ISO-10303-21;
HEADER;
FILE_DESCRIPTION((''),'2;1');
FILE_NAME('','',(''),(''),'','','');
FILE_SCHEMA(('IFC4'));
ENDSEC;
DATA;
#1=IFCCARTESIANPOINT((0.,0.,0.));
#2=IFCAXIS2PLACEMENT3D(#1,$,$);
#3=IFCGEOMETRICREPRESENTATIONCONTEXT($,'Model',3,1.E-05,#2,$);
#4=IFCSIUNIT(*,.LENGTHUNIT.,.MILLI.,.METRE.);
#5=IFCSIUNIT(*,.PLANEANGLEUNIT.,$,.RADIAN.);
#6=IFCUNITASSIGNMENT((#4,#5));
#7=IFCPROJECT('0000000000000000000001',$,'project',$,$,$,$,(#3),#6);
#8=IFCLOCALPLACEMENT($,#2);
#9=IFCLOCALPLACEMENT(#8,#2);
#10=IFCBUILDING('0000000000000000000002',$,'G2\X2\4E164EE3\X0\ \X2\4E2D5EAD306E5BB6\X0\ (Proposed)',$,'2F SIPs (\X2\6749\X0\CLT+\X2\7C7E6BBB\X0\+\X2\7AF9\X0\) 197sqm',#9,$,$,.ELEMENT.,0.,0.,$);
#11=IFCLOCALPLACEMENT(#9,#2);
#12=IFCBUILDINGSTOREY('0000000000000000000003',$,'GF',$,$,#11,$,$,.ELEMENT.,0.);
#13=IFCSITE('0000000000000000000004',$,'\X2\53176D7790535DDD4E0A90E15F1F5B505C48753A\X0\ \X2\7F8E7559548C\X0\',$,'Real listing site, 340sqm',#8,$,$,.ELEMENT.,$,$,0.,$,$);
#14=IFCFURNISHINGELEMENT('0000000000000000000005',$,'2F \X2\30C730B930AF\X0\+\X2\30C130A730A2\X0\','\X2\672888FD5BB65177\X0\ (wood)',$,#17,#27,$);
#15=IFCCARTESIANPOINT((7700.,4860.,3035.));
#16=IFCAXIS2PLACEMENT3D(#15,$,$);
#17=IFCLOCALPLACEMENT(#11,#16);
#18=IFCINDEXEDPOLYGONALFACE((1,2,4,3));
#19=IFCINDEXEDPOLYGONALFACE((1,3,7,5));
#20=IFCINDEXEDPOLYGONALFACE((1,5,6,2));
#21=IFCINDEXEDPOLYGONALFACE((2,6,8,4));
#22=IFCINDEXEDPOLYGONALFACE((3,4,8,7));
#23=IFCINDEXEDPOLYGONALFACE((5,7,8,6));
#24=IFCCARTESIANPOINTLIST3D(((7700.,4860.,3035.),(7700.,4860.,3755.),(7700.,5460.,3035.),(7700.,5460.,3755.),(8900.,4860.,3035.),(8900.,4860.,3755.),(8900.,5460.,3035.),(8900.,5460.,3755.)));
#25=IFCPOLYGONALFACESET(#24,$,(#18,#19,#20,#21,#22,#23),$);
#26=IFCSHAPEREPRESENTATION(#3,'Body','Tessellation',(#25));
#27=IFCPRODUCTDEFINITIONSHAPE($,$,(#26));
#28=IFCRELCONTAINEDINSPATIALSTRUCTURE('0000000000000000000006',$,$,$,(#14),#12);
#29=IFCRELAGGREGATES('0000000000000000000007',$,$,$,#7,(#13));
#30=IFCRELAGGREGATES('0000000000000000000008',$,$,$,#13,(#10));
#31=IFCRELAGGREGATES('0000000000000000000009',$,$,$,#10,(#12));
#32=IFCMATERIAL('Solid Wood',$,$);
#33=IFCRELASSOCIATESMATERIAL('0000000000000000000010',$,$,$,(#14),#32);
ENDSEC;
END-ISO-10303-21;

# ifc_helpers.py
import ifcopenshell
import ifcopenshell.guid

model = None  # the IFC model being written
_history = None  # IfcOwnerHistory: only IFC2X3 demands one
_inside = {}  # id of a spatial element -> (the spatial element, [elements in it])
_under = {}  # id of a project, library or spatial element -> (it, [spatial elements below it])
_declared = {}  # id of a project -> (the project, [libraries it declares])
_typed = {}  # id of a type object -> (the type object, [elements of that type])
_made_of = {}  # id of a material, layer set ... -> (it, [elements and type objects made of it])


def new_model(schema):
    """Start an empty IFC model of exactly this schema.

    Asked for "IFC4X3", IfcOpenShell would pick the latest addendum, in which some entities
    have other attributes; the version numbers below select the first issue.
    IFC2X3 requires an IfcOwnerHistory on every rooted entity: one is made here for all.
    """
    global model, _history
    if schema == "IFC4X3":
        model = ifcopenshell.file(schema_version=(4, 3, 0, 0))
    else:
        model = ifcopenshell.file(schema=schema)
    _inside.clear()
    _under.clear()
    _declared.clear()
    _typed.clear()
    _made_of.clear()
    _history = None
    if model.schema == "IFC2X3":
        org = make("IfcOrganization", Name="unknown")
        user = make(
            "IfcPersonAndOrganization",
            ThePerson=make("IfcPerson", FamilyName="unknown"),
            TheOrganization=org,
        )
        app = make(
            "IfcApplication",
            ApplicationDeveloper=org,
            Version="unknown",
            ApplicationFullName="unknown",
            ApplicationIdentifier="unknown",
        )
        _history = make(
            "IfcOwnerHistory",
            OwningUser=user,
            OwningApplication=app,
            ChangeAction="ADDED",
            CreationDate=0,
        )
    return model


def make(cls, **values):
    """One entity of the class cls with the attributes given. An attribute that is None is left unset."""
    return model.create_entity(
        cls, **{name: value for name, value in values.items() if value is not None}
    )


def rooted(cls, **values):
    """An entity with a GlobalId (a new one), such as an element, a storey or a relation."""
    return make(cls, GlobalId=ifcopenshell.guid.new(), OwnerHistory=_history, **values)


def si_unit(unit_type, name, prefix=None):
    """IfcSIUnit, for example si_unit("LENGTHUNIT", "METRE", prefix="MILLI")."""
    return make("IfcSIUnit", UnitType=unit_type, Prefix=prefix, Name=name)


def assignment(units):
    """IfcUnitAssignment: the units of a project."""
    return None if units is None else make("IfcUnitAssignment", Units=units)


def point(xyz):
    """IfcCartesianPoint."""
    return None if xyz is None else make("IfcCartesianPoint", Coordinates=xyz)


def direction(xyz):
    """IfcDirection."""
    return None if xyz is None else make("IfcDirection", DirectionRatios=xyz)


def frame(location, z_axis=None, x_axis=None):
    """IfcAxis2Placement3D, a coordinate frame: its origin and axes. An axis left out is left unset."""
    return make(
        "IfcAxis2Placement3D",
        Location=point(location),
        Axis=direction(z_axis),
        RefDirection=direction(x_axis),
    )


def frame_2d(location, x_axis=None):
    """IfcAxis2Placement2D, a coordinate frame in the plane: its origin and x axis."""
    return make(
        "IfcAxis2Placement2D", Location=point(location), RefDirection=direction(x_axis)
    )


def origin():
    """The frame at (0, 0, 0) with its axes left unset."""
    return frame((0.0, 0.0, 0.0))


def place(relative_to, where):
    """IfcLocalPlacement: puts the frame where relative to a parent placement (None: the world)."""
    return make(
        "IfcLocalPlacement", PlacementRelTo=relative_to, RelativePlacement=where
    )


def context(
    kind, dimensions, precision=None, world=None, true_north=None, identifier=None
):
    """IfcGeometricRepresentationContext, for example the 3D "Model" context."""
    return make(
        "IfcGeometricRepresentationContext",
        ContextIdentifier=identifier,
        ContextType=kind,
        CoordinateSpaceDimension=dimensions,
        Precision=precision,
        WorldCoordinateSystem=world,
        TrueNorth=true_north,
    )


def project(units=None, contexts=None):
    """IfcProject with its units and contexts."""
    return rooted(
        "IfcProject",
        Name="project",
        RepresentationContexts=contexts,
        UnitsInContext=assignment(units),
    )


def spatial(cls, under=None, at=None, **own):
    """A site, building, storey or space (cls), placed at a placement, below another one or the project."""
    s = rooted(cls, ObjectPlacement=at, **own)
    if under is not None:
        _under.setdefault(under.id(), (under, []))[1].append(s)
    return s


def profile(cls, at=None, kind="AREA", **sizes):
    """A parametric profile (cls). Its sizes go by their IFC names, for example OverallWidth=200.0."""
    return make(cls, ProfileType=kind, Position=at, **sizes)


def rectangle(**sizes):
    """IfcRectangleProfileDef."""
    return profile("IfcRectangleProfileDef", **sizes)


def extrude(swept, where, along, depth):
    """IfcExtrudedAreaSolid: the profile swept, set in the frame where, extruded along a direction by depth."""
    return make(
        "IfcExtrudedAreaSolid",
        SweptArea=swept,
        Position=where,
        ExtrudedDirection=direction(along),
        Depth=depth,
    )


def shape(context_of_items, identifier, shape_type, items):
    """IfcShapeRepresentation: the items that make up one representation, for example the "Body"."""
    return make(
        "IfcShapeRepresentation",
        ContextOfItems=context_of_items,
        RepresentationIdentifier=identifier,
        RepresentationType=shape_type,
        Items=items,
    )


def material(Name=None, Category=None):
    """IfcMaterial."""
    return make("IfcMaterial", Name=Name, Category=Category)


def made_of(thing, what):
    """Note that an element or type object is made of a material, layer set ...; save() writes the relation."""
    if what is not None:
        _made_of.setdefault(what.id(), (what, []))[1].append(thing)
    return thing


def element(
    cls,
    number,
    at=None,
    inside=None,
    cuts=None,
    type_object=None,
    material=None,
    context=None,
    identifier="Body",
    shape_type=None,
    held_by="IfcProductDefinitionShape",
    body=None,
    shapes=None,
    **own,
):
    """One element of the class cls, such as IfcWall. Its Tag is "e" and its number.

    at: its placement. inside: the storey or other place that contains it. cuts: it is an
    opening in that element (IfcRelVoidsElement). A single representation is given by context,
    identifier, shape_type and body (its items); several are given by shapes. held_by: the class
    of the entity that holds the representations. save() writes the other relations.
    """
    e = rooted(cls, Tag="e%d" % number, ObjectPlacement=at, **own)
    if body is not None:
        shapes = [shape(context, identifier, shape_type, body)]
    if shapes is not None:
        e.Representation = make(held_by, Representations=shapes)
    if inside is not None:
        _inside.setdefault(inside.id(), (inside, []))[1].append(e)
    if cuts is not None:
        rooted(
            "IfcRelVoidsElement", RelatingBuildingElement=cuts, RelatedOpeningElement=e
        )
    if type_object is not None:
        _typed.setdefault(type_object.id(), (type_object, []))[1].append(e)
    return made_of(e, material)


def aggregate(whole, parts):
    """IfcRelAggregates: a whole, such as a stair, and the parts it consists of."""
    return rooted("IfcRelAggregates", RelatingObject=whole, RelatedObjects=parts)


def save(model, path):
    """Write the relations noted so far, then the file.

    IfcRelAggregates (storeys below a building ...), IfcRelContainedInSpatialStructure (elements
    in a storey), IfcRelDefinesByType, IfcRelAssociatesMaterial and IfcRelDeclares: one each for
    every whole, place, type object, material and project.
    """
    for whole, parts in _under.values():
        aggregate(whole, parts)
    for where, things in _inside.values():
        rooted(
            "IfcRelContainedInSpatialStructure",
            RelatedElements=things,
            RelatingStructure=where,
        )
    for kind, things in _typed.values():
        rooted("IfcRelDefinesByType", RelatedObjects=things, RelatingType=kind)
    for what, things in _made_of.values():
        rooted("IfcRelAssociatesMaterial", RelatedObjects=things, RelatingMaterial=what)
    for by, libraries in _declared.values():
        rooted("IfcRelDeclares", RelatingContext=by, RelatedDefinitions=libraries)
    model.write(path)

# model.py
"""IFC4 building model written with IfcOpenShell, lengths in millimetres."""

from ifc_helpers import new_model, si_unit, frame, frame_2d, origin, place, context, project, spatial, rectangle, extrude, material, element, save


model = new_model("IFC4")

# Units and contexts
model_context = context("Model", 3, precision=1e-05, world=origin())
ifc_project = project(units=[si_unit("LENGTHUNIT", "METRE", prefix="MILLI"), si_unit("PLANEANGLEUNIT", "RADIAN")], contexts=[model_context])

# Site, building, storey
site_placement = place(None, origin())
site = spatial("IfcSite", under=ifc_project, at=site_placement, Name="北海道川上郡弟子屈町 美留和", ObjectType="Real listing site, 340sqm", CompositionType="ELEMENT", RefElevation=0.0)
building_placement = place(site_placement, origin())
building = spatial("IfcBuilding", under=site, at=building_placement, Name="G2世代 中庭の家 (Proposed)", ObjectType="2F SIPs (杉CLT+籾殻+竹) 197sqm", CompositionType="ELEMENT", ElevationOfRefHeight=0.0, ElevationOfTerrain=0.0)
storey_placement = place(building_placement, origin())
storey = spatial("IfcBuildingStorey", under=building, at=storey_placement, Name="GF", CompositionType="ELEMENT", Elevation=0.0)

# Shared definitions
ifc_material_1 = material(Name="Solid Wood")

# Furnishing element
furnishing_1_placement = place(storey_placement, frame((7700.0, 4860.0, 3035.0)))
element("IfcFurnishingElement", 1, at=furnishing_1_placement, inside=storey, material=ifc_material_1, Name="2F デスク+チェア", Description="木製家具 (wood)", context=model_context, shape_type="SweptSolid", body=[
    extrude(rectangle(XDim=1200.0, YDim=600.0, at=frame_2d((600.0, 300.0))), frame((7700.0, 4860.0, 3035.0)), (0.0, 0.0, 1.0), 720.0),
])

save(model, "model.ifc")
